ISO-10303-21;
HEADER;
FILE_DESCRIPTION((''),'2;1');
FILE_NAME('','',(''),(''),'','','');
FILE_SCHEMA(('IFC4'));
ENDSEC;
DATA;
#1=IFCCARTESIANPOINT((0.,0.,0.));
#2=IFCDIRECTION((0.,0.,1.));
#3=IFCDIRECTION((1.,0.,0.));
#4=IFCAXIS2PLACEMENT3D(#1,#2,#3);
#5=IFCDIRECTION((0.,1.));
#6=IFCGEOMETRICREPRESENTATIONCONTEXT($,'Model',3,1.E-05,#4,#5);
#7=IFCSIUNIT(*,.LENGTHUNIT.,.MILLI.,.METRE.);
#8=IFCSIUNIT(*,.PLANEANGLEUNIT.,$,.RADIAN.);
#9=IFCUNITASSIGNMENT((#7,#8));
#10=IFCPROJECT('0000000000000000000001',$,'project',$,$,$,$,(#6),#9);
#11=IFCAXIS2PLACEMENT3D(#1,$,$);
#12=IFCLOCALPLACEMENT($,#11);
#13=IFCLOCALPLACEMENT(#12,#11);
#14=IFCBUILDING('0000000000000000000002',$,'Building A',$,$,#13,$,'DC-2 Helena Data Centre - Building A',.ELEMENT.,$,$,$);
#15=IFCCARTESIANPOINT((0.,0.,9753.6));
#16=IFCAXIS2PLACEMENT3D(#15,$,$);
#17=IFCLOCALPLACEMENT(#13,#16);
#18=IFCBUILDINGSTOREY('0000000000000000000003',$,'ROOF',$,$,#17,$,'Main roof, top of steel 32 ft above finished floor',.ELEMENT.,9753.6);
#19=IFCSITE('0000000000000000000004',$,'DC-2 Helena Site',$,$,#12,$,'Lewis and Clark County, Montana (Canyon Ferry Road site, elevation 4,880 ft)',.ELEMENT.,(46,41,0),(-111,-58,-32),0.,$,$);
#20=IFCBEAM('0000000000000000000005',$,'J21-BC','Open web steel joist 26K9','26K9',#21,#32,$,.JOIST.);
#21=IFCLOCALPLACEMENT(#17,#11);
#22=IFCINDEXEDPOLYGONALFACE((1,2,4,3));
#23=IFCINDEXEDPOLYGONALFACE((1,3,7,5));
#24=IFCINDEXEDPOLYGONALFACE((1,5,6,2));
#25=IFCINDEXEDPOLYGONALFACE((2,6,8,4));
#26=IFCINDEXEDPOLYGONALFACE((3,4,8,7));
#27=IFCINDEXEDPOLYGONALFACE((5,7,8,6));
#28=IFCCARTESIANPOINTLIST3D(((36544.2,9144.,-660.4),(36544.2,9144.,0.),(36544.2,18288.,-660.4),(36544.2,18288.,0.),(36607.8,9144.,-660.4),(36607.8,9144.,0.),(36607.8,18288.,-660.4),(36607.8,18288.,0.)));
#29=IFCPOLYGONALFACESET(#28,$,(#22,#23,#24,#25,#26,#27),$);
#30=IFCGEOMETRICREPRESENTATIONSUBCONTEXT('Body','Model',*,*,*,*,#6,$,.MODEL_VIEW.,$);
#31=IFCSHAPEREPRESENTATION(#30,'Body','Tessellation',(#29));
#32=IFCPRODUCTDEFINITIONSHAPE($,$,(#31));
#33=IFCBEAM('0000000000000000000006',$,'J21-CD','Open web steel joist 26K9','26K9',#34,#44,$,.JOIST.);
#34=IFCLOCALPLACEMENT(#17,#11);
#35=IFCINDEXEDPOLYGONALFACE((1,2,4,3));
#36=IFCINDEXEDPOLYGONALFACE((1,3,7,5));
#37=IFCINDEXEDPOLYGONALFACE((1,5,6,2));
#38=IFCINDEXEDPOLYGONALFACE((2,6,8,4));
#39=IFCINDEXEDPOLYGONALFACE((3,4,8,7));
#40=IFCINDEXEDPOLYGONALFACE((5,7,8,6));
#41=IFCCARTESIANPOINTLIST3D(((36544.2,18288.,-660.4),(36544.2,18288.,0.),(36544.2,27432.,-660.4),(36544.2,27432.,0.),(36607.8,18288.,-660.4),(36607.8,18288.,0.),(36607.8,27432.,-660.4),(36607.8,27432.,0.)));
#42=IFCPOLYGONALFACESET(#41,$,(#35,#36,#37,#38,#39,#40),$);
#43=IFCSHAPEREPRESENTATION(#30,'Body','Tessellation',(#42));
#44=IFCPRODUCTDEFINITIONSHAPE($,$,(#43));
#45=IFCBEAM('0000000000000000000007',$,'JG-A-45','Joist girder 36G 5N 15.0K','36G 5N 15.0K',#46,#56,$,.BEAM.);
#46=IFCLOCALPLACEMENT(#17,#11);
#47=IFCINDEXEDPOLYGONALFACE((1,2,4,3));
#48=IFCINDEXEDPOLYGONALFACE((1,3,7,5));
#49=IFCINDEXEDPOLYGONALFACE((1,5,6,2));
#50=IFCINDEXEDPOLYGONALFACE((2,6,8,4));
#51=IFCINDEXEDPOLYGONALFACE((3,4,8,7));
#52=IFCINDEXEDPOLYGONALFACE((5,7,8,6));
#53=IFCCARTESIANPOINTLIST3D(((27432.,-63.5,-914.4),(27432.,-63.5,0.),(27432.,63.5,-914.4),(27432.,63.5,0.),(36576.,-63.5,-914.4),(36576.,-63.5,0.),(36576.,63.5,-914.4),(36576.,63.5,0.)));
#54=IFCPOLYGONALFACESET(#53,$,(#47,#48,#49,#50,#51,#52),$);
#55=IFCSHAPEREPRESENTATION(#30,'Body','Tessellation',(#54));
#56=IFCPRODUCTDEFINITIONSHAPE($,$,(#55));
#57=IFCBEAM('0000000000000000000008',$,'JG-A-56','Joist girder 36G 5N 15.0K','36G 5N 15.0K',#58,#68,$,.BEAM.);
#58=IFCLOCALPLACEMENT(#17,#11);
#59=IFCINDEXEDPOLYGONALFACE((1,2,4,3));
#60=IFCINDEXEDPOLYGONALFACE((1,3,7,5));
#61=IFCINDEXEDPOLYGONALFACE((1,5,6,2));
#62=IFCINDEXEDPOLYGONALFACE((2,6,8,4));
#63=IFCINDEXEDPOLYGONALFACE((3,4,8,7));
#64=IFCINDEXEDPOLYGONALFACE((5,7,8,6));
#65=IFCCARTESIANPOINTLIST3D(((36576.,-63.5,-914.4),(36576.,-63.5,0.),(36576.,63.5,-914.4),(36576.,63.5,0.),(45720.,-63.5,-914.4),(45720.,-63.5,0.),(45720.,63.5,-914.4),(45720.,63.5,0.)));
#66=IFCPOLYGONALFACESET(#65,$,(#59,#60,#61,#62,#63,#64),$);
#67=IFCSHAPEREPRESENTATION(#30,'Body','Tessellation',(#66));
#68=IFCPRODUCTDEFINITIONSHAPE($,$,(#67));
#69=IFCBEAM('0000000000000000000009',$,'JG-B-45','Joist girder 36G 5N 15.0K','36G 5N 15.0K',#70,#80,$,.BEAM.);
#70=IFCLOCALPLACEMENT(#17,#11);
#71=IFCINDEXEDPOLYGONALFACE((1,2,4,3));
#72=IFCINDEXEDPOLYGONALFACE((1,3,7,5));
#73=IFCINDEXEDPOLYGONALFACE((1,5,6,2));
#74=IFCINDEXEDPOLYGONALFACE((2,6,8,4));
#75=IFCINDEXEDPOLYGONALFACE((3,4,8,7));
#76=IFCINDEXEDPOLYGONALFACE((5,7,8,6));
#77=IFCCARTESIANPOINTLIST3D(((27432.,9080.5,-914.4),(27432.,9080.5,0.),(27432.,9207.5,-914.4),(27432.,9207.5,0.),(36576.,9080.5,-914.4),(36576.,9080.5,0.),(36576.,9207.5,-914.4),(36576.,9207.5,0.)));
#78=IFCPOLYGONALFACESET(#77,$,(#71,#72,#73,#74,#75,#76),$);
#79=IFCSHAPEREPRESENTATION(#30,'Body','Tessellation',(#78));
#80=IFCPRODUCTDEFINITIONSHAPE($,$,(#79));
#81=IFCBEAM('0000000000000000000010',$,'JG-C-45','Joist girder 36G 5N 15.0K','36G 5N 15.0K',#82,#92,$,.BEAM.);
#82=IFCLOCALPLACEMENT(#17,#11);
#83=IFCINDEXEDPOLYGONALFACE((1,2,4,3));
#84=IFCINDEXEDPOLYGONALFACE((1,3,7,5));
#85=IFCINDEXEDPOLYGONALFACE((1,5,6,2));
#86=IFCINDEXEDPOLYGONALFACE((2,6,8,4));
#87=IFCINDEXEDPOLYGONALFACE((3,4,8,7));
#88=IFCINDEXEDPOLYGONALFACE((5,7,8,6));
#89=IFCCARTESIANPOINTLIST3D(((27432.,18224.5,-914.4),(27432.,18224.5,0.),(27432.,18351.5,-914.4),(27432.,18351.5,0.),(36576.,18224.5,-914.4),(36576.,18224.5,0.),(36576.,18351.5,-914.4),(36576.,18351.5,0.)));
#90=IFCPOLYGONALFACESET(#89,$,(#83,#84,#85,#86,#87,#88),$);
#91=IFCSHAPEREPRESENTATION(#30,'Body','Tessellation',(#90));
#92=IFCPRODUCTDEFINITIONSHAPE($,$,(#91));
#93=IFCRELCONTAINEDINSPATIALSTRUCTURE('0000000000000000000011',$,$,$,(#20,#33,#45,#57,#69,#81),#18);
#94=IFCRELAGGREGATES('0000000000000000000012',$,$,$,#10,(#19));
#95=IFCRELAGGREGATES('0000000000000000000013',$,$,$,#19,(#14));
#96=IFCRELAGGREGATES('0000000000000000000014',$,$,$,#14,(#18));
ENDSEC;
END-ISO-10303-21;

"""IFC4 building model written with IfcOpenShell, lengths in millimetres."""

from ifc_helpers import new_model, si_unit, direction, frame, origin, origin_with_axes, origin_2d, place, context, subcontext, project, spatial, rectangle, extrude, element, save


model = new_model("IFC4")

# Units and contexts
model_context = context("Model", 3, precision=1e-05, world=origin_with_axes(), true_north=direction((0.0, 1.0)))
body_context = subcontext(model_context, "Body", "Model", "MODEL_VIEW")
ifc_project = project(units=[si_unit("LENGTHUNIT", "METRE", prefix="MILLI"), si_unit("PLANEANGLEUNIT", "RADIAN")], contexts=[model_context])

# Site, building, storey
site_placement = place(None, origin())
site = spatial("IfcSite", under=ifc_project, at=site_placement, Name="DC-2 Helena Site", LongName="Lewis and Clark County, Montana (Canyon Ferry Road site, elevation 4,880 ft)", CompositionType="ELEMENT", RefLatitude=(46, 41, 0), RefLongitude=(-111, -58, -32), RefElevation=0.0)
building_placement = place(site_placement, origin())
building = spatial("IfcBuilding", under=site, at=building_placement, Name="Building A", LongName="DC-2 Helena Data Centre - Building A", CompositionType="ELEMENT")
storey_placement = place(building_placement, frame((0.0, 0.0, 9753.6)))
storey = spatial("IfcBuildingStorey", under=building, at=storey_placement, Name="ROOF", LongName="Main roof, top of steel 32 ft above finished floor", CompositionType="ELEMENT", Elevation=9753.6)

# Beams
placement_1 = place(storey_placement, frame((27432.0, 0.0, 0.0)))
placement_2 = place(storey_placement, frame((27432.0, 9144.0, 0.0)))
placement_3 = place(storey_placement, frame((27432.0, 18288.0, 0.0)))
placement_4 = place(storey_placement, frame((36576.0, 0.0, 0.0)))
beam_1_placement = place(storey_placement, frame((36576.0, 9144.0, 0.0)))
element("IfcBeam", 1, at=beam_1_placement, inside=storey, Name="J21-BC", Description="Open web steel joist 26K9", ObjectType="26K9", PredefinedType="JOIST", context=body_context, shape_type="SweptSolid", body=[
    extrude(rectangle(XDim=63.5, YDim=660.4, at=origin_2d()), frame((0.0, 0.0, -330.2), z_axis=(0.0, 1.0, 0.0), x_axis=(1.0, 0.0, 0.0)), (0.0, 0.0, 1.0), 9144.0),
])
beam_2_placement = place(storey_placement, frame((36576.0, 18288.0, 0.0)))
element("IfcBeam", 2, at=beam_2_placement, inside=storey, Name="J21-CD", Description="Open web steel joist 26K9", ObjectType="26K9", PredefinedType="JOIST", context=body_context, shape_type="SweptSolid", body=[
    extrude(rectangle(XDim=63.5, YDim=660.4, at=origin_2d()), frame((0.0, 0.0, -330.2), z_axis=(0.0, 1.0, 0.0), x_axis=(1.0, 0.0, 0.0)), (0.0, 0.0, 1.0), 9144.0),
])
element("IfcBeam", 3, at=placement_1, inside=storey, Name="JG-A-45", Description="Joist girder 36G 5N 15.0K", ObjectType="36G 5N 15.0K", PredefinedType="BEAM", context=body_context, shape_type="SweptSolid", body=[
    extrude(rectangle(XDim=127.0, YDim=914.4, at=origin_2d()), frame((0.0, 0.0, -457.2), z_axis=(1.0, 0.0, 0.0), x_axis=(0.0, 1.0, 0.0)), (0.0, 0.0, 1.0), 9144.0),
])
element("IfcBeam", 4, at=placement_4, inside=storey, Name="JG-A-56", Description="Joist girder 36G 5N 15.0K", ObjectType="36G 5N 15.0K", PredefinedType="BEAM", context=body_context, shape_type="SweptSolid", body=[
    extrude(rectangle(XDim=127.0, YDim=914.4, at=origin_2d()), frame((0.0, 0.0, -457.2), z_axis=(1.0, 0.0, 0.0), x_axis=(0.0, 1.0, 0.0)), (0.0, 0.0, 1.0), 9144.0),
])
element("IfcBeam", 5, at=placement_2, inside=storey, Name="JG-B-45", Description="Joist girder 36G 5N 15.0K", ObjectType="36G 5N 15.0K", PredefinedType="BEAM", context=body_context, shape_type="SweptSolid", body=[
    extrude(rectangle(XDim=127.0, YDim=914.4, at=origin_2d()), frame((0.0, 0.0, -457.2), z_axis=(1.0, 0.0, 0.0), x_axis=(0.0, 1.0, 0.0)), (0.0, 0.0, 1.0), 9144.0),
])
element("IfcBeam", 6, at=placement_3, inside=storey, Name="JG-C-45", Description="Joist girder 36G 5N 15.0K", ObjectType="36G 5N 15.0K", PredefinedType="BEAM", context=body_context, shape_type="SweptSolid", body=[
    extrude(rectangle(XDim=127.0, YDim=914.4, at=origin_2d()), frame((0.0, 0.0, -457.2), z_axis=(1.0, 0.0, 0.0), x_axis=(0.0, 1.0, 0.0)), (0.0, 0.0, 1.0), 9144.0),
])

save(model, "model.ifc")
